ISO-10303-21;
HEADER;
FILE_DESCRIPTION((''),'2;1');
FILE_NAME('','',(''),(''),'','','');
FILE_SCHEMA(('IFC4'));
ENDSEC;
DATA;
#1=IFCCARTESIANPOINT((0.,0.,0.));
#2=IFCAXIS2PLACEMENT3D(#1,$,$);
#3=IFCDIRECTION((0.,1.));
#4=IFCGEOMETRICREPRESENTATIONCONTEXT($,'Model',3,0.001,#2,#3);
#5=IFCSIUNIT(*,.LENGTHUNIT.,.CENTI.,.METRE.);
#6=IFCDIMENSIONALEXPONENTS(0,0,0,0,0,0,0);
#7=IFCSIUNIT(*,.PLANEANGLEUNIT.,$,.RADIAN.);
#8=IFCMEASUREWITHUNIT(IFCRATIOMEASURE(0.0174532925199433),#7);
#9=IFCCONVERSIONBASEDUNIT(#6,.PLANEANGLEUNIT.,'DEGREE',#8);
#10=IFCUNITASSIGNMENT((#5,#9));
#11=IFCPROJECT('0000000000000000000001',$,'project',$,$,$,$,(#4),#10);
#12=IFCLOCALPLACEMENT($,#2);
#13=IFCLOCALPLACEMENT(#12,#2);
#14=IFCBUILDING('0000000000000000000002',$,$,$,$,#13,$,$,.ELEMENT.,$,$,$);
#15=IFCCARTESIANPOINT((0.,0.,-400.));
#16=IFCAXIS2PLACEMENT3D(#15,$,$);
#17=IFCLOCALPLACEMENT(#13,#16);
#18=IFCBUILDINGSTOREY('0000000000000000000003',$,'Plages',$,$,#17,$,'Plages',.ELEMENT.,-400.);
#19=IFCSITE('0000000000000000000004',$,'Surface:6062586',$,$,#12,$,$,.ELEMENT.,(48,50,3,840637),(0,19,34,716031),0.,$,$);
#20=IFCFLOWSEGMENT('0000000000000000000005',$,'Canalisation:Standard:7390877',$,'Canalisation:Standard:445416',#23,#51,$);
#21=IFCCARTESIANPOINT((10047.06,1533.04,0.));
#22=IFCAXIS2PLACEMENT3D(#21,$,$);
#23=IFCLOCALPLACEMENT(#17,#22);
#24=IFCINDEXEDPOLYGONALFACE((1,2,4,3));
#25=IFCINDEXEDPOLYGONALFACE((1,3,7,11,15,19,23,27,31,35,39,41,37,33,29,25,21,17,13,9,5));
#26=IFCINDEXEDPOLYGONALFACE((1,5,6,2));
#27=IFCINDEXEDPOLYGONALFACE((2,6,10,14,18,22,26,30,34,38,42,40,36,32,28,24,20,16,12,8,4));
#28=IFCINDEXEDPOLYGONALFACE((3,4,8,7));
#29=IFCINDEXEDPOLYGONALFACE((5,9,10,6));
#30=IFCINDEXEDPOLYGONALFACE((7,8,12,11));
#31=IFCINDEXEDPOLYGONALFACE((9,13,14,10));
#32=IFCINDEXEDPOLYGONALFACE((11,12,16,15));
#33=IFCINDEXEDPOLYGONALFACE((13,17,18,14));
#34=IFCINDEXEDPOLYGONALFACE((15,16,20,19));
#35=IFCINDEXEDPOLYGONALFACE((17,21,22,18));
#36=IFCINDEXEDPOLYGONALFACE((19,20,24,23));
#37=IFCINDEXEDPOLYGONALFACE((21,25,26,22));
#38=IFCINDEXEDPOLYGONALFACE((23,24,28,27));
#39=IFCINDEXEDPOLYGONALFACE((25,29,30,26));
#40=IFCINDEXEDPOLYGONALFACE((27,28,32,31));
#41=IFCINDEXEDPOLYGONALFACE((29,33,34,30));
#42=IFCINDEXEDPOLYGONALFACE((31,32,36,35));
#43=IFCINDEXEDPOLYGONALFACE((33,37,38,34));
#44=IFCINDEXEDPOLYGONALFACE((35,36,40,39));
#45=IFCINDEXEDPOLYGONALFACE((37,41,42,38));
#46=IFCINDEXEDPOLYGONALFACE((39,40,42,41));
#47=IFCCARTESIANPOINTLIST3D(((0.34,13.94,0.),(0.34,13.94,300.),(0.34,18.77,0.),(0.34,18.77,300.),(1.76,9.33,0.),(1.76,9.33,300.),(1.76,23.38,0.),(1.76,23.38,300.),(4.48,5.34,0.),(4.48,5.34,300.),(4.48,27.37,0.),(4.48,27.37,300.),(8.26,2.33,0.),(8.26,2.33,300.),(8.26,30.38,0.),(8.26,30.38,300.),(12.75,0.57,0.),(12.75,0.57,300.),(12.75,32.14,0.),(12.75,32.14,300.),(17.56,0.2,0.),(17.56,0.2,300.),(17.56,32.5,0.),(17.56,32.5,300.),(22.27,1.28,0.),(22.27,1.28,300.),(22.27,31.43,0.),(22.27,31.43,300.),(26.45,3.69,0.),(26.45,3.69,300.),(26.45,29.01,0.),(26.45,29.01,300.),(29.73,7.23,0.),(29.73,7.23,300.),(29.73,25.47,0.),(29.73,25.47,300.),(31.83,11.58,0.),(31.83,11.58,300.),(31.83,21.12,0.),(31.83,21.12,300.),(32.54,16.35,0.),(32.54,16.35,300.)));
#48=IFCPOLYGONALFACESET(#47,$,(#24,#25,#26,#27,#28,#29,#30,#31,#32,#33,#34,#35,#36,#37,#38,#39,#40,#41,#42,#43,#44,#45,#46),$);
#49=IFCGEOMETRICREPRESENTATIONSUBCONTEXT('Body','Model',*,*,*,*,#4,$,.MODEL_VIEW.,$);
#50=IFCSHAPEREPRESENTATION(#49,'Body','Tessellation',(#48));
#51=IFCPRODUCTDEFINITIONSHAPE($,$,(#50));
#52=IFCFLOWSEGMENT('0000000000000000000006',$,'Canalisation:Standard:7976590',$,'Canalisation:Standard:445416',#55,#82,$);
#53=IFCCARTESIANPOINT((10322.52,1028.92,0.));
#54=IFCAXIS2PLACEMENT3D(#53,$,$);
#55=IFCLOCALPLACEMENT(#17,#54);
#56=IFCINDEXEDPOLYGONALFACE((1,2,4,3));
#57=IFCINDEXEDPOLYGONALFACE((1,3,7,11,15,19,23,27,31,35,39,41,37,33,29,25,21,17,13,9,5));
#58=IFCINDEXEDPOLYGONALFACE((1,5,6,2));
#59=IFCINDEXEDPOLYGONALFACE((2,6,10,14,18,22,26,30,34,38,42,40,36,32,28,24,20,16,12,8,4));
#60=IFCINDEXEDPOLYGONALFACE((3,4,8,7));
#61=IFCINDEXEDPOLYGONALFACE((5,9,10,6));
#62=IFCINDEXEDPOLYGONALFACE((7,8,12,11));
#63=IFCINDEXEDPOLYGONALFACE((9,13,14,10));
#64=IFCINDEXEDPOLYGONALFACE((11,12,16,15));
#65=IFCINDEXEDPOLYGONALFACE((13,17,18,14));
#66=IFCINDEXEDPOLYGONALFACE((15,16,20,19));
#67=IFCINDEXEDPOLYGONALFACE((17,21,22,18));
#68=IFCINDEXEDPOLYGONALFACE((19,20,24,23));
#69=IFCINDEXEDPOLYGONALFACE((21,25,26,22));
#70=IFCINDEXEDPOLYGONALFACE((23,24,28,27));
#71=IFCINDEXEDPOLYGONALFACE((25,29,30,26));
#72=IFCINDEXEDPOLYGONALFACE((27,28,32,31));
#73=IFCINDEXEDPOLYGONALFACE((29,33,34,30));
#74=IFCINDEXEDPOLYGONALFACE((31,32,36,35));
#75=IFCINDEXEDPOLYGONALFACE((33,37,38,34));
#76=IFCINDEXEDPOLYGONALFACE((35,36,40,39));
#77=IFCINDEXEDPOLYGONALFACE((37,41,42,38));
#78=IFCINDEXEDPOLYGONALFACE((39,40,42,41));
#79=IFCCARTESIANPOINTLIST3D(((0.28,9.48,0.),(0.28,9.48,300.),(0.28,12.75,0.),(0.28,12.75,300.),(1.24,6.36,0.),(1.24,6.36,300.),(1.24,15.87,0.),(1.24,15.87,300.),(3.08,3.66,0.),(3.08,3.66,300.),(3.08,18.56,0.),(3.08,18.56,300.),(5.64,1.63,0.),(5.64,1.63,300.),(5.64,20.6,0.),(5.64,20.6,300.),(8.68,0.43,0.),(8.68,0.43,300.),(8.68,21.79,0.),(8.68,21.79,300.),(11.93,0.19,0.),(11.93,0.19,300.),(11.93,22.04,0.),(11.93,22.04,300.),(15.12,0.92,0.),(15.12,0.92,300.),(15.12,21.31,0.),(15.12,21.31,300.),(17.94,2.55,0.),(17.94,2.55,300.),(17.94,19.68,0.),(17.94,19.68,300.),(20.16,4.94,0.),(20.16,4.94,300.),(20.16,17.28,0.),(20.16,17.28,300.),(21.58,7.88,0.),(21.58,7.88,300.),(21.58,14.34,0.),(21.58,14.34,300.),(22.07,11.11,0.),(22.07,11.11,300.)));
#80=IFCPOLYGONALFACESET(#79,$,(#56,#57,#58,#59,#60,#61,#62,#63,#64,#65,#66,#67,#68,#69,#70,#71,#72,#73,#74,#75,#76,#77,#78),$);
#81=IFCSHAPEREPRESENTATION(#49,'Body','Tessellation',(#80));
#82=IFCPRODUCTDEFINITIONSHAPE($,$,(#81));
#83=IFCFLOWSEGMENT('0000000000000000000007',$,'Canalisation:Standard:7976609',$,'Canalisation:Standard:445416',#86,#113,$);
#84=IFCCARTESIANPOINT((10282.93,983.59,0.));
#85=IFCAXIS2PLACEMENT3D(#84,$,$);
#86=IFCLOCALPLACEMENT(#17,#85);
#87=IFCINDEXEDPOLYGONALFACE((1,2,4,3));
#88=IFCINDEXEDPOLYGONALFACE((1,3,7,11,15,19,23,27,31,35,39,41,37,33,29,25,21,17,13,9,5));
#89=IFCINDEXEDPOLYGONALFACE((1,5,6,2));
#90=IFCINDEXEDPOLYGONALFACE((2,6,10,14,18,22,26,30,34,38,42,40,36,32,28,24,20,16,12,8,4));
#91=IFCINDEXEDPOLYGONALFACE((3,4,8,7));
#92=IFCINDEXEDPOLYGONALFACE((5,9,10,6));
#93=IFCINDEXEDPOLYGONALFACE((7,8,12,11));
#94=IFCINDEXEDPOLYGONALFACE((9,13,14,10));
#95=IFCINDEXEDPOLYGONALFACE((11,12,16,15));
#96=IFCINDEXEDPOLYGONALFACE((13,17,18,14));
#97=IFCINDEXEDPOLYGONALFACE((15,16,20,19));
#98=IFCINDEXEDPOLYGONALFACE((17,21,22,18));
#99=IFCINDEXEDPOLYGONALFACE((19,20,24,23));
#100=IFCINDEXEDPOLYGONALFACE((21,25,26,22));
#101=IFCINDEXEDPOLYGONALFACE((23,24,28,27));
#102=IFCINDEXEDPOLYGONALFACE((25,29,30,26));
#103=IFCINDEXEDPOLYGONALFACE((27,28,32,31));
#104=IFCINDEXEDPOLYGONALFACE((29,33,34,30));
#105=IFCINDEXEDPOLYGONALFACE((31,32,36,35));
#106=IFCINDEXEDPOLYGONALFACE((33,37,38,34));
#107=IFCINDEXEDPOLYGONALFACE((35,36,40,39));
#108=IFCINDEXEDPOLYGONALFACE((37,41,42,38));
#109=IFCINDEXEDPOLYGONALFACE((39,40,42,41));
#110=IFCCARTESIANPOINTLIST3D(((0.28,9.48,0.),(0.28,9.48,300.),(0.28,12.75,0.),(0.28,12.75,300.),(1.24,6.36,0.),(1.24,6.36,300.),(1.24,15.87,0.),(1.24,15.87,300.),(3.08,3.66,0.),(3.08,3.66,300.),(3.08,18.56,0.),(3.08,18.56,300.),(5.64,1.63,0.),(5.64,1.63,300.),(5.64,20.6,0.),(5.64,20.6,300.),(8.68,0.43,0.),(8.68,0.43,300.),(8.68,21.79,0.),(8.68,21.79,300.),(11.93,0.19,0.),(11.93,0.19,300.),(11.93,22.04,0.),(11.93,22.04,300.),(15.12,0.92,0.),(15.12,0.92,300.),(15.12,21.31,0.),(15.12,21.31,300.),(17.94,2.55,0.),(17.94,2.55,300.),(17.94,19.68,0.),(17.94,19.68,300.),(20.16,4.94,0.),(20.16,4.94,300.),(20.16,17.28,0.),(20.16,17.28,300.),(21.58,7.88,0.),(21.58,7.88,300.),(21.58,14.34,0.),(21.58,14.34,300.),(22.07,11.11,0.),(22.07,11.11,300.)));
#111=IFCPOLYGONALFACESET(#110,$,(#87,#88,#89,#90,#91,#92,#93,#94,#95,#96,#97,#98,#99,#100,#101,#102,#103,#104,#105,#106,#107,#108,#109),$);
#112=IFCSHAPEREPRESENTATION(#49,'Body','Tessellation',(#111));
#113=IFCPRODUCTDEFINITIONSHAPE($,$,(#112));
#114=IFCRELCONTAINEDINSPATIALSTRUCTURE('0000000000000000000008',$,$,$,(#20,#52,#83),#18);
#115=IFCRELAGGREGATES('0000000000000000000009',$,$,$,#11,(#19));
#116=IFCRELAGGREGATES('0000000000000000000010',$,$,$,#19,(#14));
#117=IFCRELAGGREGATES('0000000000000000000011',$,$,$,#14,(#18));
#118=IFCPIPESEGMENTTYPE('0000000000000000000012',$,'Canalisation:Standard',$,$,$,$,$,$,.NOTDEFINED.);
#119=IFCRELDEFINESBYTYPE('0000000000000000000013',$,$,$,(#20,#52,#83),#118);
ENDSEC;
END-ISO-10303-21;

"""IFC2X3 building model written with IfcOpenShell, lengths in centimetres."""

from ifc_helpers import new_model, entity, si_unit, converted_unit, direction, frame, origin, origin_2d_with_axis, place, context, subcontext, project, spatial, circle, extrude, type_object, element, save


model = new_model("IFC2X3")

# Units and contexts
model_context = context("Model", 3, precision=0.001, world=origin(), true_north=direction((0.0, 1.0)))
body_context = subcontext(model_context, "Body", "Model", "MODEL_VIEW")
ifc_project = project(units=[si_unit("LENGTHUNIT", "METRE", prefix="CENTI"), converted_unit("PLANEANGLEUNIT", "DEGREE", entity("IfcRatioMeasure", 0.0174532925199433), si_unit("PLANEANGLEUNIT", "RADIAN"), dimensions=[0, 0, 0, 0, 0, 0, 0])], contexts=[model_context])

# Site, building, storey
site_placement = place(None, origin())
site = spatial("IfcSite", under=ifc_project, at=site_placement, Name="Surface:6062586", CompositionType="ELEMENT", RefLatitude=(48, 50, 3, 840637), RefLongitude=(0, 19, 34, 716031), RefElevation=0.0)
building_placement = place(site_placement, origin())
building = spatial("IfcBuilding", under=site, at=building_placement, CompositionType="ELEMENT")
storey_placement = place(building_placement, frame((0.0, 0.0, -400.0)))
storey = spatial("IfcBuildingStorey", under=building, at=storey_placement, Name="Plages", LongName="Plages", CompositionType="ELEMENT", Elevation=-400.0)

# Flow segments
pipe_segment_type = type_object("IfcPipeSegmentType", Name="Canalisation:Standard", PredefinedType="NOTDEFINED")
flow_segment_placement = place(storey_placement, frame((10047.06, 1533.04, 0.0)))
element("IfcFlowSegment", 1, at=flow_segment_placement, inside=storey, type_object=pipe_segment_type, Name="Canalisation:Standard:7390877", ObjectType="Canalisation:Standard:445416", context=body_context, shape_type="SweptSolid", body=[
    extrude(circle(Radius=16.19, at=origin_2d_with_axis()), frame((16.35, 16.35, 0.0)), (0.0, 0.0, 1.0), 300.0),
])
for number, where, name in (
    (2, (10322.52, 1028.92, 0.0), "Canalisation:Standard:7976590"),
    (3, (10282.93, 983.59, 0.0), "Canalisation:Standard:7976609"),
):
    element("IfcFlowSegment", number, at=place(storey_placement, frame(where)), inside=storey, type_object=pipe_segment_type, Name=name, ObjectType="Canalisation:Standard:445416", context=body_context, shape_type="SweptSolid", body=[
        extrude(circle(Radius=10.95, at=origin_2d_with_axis()), frame((11.11, 11.11, 0.0)), (0.0, 0.0, 1.0), 300.0),
    ])

save(model, "model.ifc")
